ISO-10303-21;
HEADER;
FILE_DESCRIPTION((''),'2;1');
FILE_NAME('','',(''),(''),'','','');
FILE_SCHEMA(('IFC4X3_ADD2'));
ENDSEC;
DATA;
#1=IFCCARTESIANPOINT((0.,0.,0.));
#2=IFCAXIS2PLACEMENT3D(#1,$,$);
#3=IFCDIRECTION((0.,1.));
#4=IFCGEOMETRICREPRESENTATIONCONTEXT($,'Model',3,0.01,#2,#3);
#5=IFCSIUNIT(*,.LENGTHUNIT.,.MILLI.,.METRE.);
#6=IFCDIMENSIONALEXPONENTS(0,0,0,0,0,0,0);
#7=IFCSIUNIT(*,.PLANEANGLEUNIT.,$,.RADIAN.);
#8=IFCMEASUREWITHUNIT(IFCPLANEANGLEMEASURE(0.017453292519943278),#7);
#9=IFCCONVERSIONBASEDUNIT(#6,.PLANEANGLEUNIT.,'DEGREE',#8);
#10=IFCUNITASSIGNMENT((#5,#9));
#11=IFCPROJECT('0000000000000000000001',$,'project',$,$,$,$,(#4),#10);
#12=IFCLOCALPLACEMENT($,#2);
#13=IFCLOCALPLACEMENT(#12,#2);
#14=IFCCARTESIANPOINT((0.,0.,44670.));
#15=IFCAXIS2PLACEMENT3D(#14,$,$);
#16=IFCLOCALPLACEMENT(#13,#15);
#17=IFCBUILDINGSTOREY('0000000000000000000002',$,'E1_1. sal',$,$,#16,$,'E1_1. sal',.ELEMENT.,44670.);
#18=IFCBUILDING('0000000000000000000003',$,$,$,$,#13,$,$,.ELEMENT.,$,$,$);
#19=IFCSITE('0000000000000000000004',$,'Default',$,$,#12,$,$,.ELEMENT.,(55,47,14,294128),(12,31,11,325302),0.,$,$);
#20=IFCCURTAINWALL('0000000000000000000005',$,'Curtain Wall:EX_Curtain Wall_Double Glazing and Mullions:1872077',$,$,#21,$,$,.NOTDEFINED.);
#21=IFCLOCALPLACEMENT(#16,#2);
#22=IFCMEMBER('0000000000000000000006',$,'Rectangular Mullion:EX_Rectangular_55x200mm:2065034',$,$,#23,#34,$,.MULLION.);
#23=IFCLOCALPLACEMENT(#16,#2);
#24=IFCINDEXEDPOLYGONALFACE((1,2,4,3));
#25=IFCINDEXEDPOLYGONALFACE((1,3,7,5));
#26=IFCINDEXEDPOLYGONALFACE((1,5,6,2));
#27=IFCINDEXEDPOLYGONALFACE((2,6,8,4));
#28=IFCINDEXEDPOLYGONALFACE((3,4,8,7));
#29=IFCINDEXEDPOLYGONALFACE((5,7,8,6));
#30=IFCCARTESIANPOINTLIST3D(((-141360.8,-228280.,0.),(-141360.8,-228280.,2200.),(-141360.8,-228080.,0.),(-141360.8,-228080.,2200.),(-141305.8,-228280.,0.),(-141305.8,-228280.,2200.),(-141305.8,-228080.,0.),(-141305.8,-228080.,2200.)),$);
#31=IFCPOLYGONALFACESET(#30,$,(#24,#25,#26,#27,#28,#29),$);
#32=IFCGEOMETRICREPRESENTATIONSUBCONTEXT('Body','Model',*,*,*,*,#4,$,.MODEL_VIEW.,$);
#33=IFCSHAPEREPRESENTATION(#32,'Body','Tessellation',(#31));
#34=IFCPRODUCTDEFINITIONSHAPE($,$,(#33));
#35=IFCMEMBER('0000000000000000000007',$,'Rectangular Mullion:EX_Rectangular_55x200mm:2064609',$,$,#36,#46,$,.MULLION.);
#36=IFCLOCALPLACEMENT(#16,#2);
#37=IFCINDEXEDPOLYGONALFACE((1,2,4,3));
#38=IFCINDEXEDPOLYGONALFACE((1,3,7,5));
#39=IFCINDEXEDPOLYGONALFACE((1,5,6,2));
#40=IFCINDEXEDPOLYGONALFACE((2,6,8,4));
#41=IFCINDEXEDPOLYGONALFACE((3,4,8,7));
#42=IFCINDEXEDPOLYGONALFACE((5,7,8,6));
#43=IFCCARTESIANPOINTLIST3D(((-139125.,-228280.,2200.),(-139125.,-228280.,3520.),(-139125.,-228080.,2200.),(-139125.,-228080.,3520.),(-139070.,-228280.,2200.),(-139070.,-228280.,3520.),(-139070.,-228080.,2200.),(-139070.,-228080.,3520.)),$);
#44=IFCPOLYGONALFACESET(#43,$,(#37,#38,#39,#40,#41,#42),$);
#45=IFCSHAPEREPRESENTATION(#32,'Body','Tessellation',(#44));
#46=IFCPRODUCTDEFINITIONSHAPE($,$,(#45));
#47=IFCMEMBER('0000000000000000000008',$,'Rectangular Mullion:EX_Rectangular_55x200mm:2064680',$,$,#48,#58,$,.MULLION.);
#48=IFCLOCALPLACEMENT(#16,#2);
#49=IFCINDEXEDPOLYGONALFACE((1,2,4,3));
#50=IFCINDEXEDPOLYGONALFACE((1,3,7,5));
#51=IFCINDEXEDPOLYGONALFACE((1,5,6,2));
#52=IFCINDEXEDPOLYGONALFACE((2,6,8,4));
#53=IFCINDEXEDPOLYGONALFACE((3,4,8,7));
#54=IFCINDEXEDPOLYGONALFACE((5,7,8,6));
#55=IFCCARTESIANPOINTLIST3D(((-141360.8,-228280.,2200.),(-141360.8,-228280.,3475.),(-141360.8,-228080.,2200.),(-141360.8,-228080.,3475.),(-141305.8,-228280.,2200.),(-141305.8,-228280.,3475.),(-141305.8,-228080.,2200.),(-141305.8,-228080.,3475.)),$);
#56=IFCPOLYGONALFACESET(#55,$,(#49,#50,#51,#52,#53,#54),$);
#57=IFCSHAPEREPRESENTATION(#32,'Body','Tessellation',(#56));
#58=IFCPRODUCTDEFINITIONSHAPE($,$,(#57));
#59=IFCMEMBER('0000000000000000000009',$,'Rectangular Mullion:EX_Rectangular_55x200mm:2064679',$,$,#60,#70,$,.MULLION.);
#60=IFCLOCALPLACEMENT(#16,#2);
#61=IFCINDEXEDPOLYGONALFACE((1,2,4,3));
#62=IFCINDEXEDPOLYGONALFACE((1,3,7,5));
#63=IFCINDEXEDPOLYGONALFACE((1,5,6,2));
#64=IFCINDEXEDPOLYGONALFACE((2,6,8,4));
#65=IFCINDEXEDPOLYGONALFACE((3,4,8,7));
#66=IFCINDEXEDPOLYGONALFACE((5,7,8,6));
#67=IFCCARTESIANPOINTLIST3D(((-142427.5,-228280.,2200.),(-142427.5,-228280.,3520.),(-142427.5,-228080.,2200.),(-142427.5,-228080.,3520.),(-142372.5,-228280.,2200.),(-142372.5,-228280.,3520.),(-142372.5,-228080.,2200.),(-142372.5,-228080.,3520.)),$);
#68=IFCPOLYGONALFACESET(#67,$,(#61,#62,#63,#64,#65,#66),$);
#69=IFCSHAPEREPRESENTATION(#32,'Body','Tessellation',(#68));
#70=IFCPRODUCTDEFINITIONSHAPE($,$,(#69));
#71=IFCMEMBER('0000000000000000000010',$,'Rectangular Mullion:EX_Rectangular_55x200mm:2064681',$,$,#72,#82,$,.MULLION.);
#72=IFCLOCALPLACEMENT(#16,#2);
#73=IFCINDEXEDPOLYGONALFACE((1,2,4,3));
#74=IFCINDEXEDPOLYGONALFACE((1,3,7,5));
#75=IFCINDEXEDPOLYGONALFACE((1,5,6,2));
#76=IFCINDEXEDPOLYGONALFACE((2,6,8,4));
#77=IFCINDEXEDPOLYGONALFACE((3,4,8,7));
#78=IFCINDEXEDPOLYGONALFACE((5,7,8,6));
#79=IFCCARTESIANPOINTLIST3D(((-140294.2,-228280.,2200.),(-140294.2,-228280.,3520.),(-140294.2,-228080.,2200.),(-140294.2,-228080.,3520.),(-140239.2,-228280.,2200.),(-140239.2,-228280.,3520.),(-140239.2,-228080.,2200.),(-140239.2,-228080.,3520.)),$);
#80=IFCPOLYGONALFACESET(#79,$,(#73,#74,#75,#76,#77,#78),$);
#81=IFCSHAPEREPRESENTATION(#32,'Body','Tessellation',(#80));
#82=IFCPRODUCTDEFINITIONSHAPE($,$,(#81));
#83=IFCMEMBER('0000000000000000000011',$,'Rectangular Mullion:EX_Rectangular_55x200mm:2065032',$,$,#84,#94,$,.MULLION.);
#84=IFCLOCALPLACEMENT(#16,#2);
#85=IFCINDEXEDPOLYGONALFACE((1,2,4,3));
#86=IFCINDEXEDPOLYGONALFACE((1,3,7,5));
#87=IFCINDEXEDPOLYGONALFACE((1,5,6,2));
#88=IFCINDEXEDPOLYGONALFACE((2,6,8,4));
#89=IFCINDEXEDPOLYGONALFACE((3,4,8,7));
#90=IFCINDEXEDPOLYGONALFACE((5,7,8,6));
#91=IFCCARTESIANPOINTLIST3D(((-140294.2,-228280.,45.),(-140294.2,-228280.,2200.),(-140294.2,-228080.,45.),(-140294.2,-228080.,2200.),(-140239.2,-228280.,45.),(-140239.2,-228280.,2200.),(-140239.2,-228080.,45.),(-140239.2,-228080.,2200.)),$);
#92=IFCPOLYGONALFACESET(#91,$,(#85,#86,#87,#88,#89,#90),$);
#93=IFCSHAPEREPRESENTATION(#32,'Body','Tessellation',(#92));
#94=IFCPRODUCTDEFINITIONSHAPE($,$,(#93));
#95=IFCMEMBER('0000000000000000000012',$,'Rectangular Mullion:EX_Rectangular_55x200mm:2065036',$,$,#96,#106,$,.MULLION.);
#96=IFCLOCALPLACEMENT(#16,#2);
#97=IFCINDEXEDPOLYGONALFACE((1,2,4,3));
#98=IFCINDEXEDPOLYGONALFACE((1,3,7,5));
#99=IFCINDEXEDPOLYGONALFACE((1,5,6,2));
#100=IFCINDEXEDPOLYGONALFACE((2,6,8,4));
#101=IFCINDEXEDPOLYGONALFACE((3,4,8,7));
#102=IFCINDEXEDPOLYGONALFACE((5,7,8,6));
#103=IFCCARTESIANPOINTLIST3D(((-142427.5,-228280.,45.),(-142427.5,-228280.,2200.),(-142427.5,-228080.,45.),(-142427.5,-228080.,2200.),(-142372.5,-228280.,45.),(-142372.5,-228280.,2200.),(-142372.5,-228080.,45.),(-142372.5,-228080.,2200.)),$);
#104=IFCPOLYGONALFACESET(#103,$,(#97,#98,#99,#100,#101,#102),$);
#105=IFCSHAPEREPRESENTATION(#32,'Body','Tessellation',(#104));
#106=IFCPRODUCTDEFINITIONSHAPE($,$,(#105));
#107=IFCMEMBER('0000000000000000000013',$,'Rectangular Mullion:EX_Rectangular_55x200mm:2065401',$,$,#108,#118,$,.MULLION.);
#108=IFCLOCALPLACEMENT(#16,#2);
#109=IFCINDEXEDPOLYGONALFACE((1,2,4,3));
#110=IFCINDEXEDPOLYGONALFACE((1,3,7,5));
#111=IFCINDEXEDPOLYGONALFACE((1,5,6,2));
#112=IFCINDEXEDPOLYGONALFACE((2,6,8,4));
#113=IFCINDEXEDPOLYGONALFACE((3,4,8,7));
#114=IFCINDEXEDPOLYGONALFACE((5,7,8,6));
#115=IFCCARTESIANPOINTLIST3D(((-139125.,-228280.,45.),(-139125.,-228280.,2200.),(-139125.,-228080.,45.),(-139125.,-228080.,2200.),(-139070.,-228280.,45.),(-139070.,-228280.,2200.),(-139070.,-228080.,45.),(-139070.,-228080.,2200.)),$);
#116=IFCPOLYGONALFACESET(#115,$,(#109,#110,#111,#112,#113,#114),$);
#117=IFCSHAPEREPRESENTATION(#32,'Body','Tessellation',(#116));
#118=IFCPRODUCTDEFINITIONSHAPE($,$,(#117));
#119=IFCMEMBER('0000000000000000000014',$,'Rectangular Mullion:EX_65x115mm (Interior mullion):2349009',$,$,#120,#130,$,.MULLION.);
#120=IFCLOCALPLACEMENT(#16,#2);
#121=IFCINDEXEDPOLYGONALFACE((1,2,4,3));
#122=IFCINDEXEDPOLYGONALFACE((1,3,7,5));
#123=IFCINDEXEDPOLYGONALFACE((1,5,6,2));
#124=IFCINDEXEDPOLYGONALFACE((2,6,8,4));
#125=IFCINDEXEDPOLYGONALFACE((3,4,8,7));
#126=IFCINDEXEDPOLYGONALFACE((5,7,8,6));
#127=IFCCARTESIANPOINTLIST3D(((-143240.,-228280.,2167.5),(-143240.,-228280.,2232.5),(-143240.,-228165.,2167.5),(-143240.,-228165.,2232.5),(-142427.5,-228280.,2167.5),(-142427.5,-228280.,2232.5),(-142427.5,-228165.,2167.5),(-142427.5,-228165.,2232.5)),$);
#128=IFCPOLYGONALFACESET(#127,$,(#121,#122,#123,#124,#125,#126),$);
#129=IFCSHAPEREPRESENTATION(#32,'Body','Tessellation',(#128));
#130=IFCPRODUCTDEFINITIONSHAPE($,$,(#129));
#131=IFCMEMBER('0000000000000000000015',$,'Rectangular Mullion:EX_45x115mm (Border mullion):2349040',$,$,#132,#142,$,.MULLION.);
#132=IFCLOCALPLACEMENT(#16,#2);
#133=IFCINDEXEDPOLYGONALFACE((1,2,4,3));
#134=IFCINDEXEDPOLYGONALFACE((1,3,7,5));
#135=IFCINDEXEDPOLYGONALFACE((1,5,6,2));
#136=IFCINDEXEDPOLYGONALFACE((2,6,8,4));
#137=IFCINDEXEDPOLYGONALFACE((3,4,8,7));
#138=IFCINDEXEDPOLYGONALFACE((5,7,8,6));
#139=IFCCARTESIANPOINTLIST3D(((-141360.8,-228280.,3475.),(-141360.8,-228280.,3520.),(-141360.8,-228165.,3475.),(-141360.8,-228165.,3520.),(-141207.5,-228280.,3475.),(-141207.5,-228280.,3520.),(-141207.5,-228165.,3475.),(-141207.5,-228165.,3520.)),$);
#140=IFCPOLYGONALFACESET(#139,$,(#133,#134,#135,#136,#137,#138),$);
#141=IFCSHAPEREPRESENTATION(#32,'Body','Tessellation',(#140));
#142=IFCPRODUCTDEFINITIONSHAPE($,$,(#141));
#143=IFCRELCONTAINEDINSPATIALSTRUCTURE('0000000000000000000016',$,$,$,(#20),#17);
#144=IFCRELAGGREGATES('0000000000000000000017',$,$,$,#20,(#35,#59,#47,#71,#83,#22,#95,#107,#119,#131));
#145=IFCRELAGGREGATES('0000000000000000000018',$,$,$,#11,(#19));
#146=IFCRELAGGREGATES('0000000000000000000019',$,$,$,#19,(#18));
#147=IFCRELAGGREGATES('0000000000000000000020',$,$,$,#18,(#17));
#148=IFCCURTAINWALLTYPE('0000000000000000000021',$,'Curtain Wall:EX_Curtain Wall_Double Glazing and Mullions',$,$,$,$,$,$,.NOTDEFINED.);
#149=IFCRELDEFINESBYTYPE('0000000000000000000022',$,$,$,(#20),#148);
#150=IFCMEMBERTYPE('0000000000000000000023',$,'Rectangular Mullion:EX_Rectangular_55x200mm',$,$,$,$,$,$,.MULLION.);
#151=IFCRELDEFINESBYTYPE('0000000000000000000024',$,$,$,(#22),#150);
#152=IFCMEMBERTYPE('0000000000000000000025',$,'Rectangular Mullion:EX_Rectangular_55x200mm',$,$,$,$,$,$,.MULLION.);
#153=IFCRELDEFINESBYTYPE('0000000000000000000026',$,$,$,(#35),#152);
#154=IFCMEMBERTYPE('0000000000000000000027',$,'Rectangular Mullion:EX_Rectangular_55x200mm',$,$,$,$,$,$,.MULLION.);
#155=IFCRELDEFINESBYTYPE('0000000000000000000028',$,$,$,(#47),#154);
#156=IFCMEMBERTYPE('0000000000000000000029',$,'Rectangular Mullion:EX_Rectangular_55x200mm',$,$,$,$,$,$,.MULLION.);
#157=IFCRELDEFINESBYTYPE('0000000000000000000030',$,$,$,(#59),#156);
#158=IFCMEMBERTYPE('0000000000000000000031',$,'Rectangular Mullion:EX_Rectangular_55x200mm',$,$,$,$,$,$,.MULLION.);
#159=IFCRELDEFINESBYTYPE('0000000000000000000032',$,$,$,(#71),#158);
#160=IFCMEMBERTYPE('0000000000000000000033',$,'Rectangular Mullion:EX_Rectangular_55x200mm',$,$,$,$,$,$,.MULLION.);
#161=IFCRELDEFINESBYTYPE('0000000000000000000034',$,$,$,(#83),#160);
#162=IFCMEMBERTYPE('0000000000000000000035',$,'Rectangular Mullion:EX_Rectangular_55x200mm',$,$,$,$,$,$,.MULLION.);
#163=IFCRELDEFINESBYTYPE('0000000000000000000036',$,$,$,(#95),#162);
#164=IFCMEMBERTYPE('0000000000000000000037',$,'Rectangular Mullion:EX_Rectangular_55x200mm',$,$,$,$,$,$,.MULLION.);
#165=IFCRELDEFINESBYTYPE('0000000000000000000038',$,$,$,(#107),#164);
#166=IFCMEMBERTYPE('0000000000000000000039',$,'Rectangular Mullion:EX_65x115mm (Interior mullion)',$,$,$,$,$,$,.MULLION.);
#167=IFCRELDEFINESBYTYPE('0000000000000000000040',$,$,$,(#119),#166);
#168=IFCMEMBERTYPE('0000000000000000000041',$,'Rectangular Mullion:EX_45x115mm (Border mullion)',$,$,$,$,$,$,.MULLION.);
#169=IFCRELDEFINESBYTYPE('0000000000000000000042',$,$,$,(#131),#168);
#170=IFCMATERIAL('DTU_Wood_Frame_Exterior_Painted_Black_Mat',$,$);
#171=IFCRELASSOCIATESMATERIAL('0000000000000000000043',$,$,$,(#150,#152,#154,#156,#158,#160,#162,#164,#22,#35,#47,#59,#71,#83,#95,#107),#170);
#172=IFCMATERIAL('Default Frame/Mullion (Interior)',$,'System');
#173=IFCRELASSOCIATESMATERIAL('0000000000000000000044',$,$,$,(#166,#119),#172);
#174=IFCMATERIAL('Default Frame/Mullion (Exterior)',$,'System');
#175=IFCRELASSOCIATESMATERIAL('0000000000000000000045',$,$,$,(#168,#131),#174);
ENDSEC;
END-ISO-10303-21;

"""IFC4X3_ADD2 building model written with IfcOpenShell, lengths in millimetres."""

from ifc_helpers import new_model, entity, si_unit, converted_unit, direction, frame, origin, origin_2d_with_axis, place, context, subcontext, project, spatial, rectangle, extrude, source, transform, mapped, material, material_profile, profile_set, profile_usage, type_object, type_shapes, element, aggregate, save


model = new_model("IFC4X3_ADD2")

# Units and contexts
model_context = context("Model", 3, precision=0.01, world=origin(), true_north=direction((0.0, 1.0)))
body_context = subcontext(model_context, "Body", "Model", "MODEL_VIEW")
ifc_project = project(units=[si_unit("LENGTHUNIT", "METRE", prefix="MILLI"), converted_unit("PLANEANGLEUNIT", "DEGREE", entity("IfcPlaneAngleMeasure", 0.017453292519943278), si_unit("PLANEANGLEUNIT", "RADIAN"), dimensions=[0, 0, 0, 0, 0, 0, 0])], contexts=[model_context])

# Site, building, storey
site_placement = place(None, origin())
site = spatial("IfcSite", under=ifc_project, at=site_placement, Name="Default", CompositionType="ELEMENT", RefLatitude=(55, 47, 14, 294128), RefLongitude=(12, 31, 11, 325302), RefElevation=0.0)
building_placement = place(site_placement, origin())
building = spatial("IfcBuilding", under=site, at=building_placement, CompositionType="ELEMENT")
storey_placement = place(building_placement, frame((0.0, 0.0, 44670.0)))
storey = spatial("IfcBuildingStorey", under=building, at=storey_placement, Name="E1_1. sal", LongName="E1_1. sal", CompositionType="ELEMENT", Elevation=44670.0)

# Curtain wall, members
curtain_wall_type_1 = type_object("IfcCurtainWallType", Name="Curtain Wall:EX_Curtain Wall_Double Glazing and Mullions", PredefinedType="NOTDEFINED")
curtain_wall_1_placement = place(storey_placement, frame((0.0, 0.0, -44670.0)))
curtain_wall_1 = element("IfcCurtainWall", 1, at=curtain_wall_1_placement, inside=storey, type_object=curtain_wall_type_1, Name="Curtain Wall:EX_Curtain Wall_Double Glazing and Mullions:1872077", PredefinedType="NOTDEFINED")
ifc_material_1 = material(Name="DTU_Wood_Frame_Exterior_Painted_Black_Mat")
ifc_material_profile_1 = material_profile(ifc_material_1, rectangle(XDim=55.0, YDim=200.0, at=origin_2d_with_axis()), Name="EX_Rectangular_55x200mm")
ifc_profile_set_1 = profile_set([ifc_material_profile_1], Name="EX_Rectangular_55x200mm")
ifc_profile_usage_1 = profile_usage(ifc_profile_set_1)
member_type_1 = type_object("IfcMemberType", Name="Rectangular Mullion:EX_Rectangular_55x200mm", PredefinedType="MULLION", material=ifc_profile_set_1)
shared_shape_1 = source(origin(), body_context, "Body", "SweptSolid", [
    extrude(rectangle(XDim=55.0, YDim=200.0, at=origin_2d_with_axis()), frame((0.0, -100.0, -2200.0), z_axis=(0.0, 0.0, 1.0), x_axis=(-1.0, 0.0, 0.0)), (0.0, 0.0, 1.0), 2200.0),
])
type_shapes(member_type_1, [shared_shape_1])
member_1_placement = place(curtain_wall_1_placement, frame((-141333.3, -228280.0, 44670.0), z_axis=(0.0, 0.0, -1.0), x_axis=(1.0, 0.0, 0.0)))
member_1 = element("IfcMember", 2, at=member_1_placement, type_object=member_type_1, material=ifc_profile_usage_1, Name="Rectangular Mullion:EX_Rectangular_55x200mm:2065034", PredefinedType="MULLION", context=body_context, shape_type="MappedRepresentation", body=[
    mapped(shared_shape_1, transform((0.0, 0.0, 0.0), scale=1.0)),
])
member_type_2 = type_object("IfcMemberType", Name="Rectangular Mullion:EX_Rectangular_55x200mm", PredefinedType="MULLION", material=ifc_profile_set_1)
shared_shape_2 = source(origin(), body_context, "Body", "SweptSolid", [
    extrude(rectangle(XDim=55.0, YDim=200.0, at=origin_2d_with_axis()), frame((-27.5, -100.0, -1320.0), z_axis=(0.0, 0.0, 1.0), x_axis=(-1.0, 0.0, 0.0)), (0.0, 0.0, 1.0), 1320.0),
])
type_shapes(member_type_2, [shared_shape_2])
member_2_placement = place(curtain_wall_1_placement, frame((-139070.0, -228280.0, 46870.0), z_axis=(0.0, 0.0, -1.0), x_axis=(1.0, 0.0, 0.0)))
member_2 = element("IfcMember", 3, at=member_2_placement, type_object=member_type_2, material=ifc_profile_usage_1, Name="Rectangular Mullion:EX_Rectangular_55x200mm:2064609", PredefinedType="MULLION", context=body_context, shape_type="MappedRepresentation", body=[
    mapped(shared_shape_2, transform((0.0, 0.0, 0.0), scale=1.0)),
])
member_type_3 = type_object("IfcMemberType", Name="Rectangular Mullion:EX_Rectangular_55x200mm", PredefinedType="MULLION", material=ifc_profile_set_1)
shared_shape_3 = source(origin(), body_context, "Body", "SweptSolid", [
    extrude(rectangle(XDim=55.0, YDim=200.0, at=origin_2d_with_axis()), frame((0.0, -100.0, -1275.0), z_axis=(0.0, 0.0, 1.0), x_axis=(-1.0, 0.0, 0.0)), (0.0, 0.0, 1.0), 1275.0),
])
type_shapes(member_type_3, [shared_shape_3])
member_3_placement = place(curtain_wall_1_placement, frame((-141333.3, -228280.0, 46870.0), z_axis=(0.0, 0.0, -1.0), x_axis=(1.0, 0.0, 0.0)))
member_3 = element("IfcMember", 4, at=member_3_placement, type_object=member_type_3, material=ifc_profile_usage_1, Name="Rectangular Mullion:EX_Rectangular_55x200mm:2064680", PredefinedType="MULLION", context=body_context, shape_type="MappedRepresentation", body=[
    mapped(shared_shape_3, transform((0.0, 0.0, 0.0), scale=1.0)),
])
member_type_4 = type_object("IfcMemberType", Name="Rectangular Mullion:EX_Rectangular_55x200mm", PredefinedType="MULLION", material=ifc_profile_set_1)
shared_shape_4 = source(origin(), body_context, "Body", "SweptSolid", [
    extrude(rectangle(XDim=55.0, YDim=200.0, at=origin_2d_with_axis()), frame((0.0, -100.0, -1320.0), z_axis=(0.0, 0.0, 1.0), x_axis=(-1.0, 0.0, 0.0)), (0.0, 0.0, 1.0), 1320.0),
])
type_shapes(member_type_4, [shared_shape_4])
member_4_placement = place(curtain_wall_1_placement, frame((-142400.0, -228280.0, 46870.0), z_axis=(0.0, 0.0, -1.0), x_axis=(1.0, 0.0, 0.0)))
member_4 = element("IfcMember", 5, at=member_4_placement, type_object=member_type_4, material=ifc_profile_usage_1, Name="Rectangular Mullion:EX_Rectangular_55x200mm:2064679", PredefinedType="MULLION", context=body_context, shape_type="MappedRepresentation", body=[
    mapped(shared_shape_4, transform((0.0, 0.0, 0.0), scale=1.0)),
])
member_type_5 = type_object("IfcMemberType", Name="Rectangular Mullion:EX_Rectangular_55x200mm", PredefinedType="MULLION", material=ifc_profile_set_1)
shared_shape_5 = source(origin(), body_context, "Body", "SweptSolid", [
    extrude(rectangle(XDim=55.0, YDim=200.0, at=origin_2d_with_axis()), frame((0.0, -100.0, -1320.0), z_axis=(0.0, 0.0, 1.0), x_axis=(-1.0, 0.0, 0.0)), (0.0, 0.0, 1.0), 1320.0),
])
type_shapes(member_type_5, [shared_shape_5])
member_5_placement = place(curtain_wall_1_placement, frame((-140266.7, -228280.0, 46870.0), z_axis=(0.0, 0.0, -1.0), x_axis=(1.0, 0.0, 0.0)))
member_5 = element("IfcMember", 6, at=member_5_placement, type_object=member_type_5, material=ifc_profile_usage_1, Name="Rectangular Mullion:EX_Rectangular_55x200mm:2064681", PredefinedType="MULLION", context=body_context, shape_type="MappedRepresentation", body=[
    mapped(shared_shape_5, transform((0.0, 0.0, 0.0), scale=1.0)),
])
member_type_6 = type_object("IfcMemberType", Name="Rectangular Mullion:EX_Rectangular_55x200mm", PredefinedType="MULLION", material=ifc_profile_set_1)
shared_shape_6 = source(origin(), body_context, "Body", "SweptSolid", [
    extrude(rectangle(XDim=55.0, YDim=200.0, at=origin_2d_with_axis()), frame((0.0, -100.0, -2155.0), z_axis=(0.0, 0.0, 1.0), x_axis=(-1.0, 0.0, 0.0)), (0.0, 0.0, 1.0), 2155.0),
])
type_shapes(member_type_6, [shared_shape_6])
member_6_placement = place(curtain_wall_1_placement, frame((-140266.7, -228280.0, 44715.0), z_axis=(0.0, 0.0, -1.0), x_axis=(1.0, 0.0, 0.0)))
member_6 = element("IfcMember", 7, at=member_6_placement, type_object=member_type_6, material=ifc_profile_usage_1, Name="Rectangular Mullion:EX_Rectangular_55x200mm:2065032", PredefinedType="MULLION", context=body_context, shape_type="MappedRepresentation", body=[
    mapped(shared_shape_6, transform((0.0, 0.0, 0.0), scale=1.0)),
])
member_type_7 = type_object("IfcMemberType", Name="Rectangular Mullion:EX_Rectangular_55x200mm", PredefinedType="MULLION", material=ifc_profile_set_1)
shared_shape_7 = source(origin(), body_context, "Body", "SweptSolid", [
    extrude(rectangle(XDim=55.0, YDim=200.0, at=origin_2d_with_axis()), frame((0.0, -100.0, -2155.0), z_axis=(0.0, 0.0, 1.0), x_axis=(-1.0, 0.0, 0.0)), (0.0, 0.0, 1.0), 2155.0),
])
type_shapes(member_type_7, [shared_shape_7])
member_7_placement = place(curtain_wall_1_placement, frame((-142400.0, -228280.0, 44715.0), z_axis=(0.0, 0.0, -1.0), x_axis=(1.0, 0.0, 0.0)))
member_7 = element("IfcMember", 8, at=member_7_placement, type_object=member_type_7, material=ifc_profile_usage_1, Name="Rectangular Mullion:EX_Rectangular_55x200mm:2065036", PredefinedType="MULLION", context=body_context, shape_type="MappedRepresentation", body=[
    mapped(shared_shape_7, transform((0.0, 0.0, 0.0), scale=1.0)),
])
member_type_8 = type_object("IfcMemberType", Name="Rectangular Mullion:EX_Rectangular_55x200mm", PredefinedType="MULLION", material=ifc_profile_set_1)
shared_shape_8 = source(origin(), body_context, "Body", "SweptSolid", [
    extrude(rectangle(XDim=55.0, YDim=200.0, at=origin_2d_with_axis()), frame((-27.5, -100.0, -2155.0), z_axis=(0.0, 0.0, 1.0), x_axis=(-1.0, 0.0, 0.0)), (0.0, 0.0, 1.0), 2155.0),
])
type_shapes(member_type_8, [shared_shape_8])
member_8_placement = place(curtain_wall_1_placement, frame((-139070.0, -228280.0, 44715.0), z_axis=(0.0, 0.0, -1.0), x_axis=(1.0, 0.0, 0.0)))
member_8 = element("IfcMember", 9, at=member_8_placement, type_object=member_type_8, material=ifc_profile_usage_1, Name="Rectangular Mullion:EX_Rectangular_55x200mm:2065401", PredefinedType="MULLION", context=body_context, shape_type="MappedRepresentation", body=[
    mapped(shared_shape_8, transform((0.0, 0.0, 0.0), scale=1.0)),
])
ifc_material_2 = material(Name="Default Frame/Mullion (Interior)", Category="System")
ifc_material_profile_2 = material_profile(ifc_material_2, rectangle(XDim=65.0, YDim=115.0, at=origin_2d_with_axis()), Name="EX_65x115mm (Interior mullion)")
ifc_profile_set_2 = profile_set([ifc_material_profile_2], Name="EX_65x115mm (Interior mullion)")
ifc_profile_usage_2 = profile_usage(ifc_profile_set_2)
member_type_9 = type_object("IfcMemberType", Name="Rectangular Mullion:EX_65x115mm (Interior mullion)", PredefinedType="MULLION", material=ifc_profile_set_2)
shared_shape_9 = source(origin(), body_context, "Body", "SweptSolid", [
    extrude(rectangle(XDim=65.0, YDim=115.0, at=origin_2d_with_axis()), frame((0.0, -57.5, -812.5), z_axis=(0.0, 0.0, 1.0), x_axis=(-1.0, 0.0, 0.0)), (0.0, 0.0, 1.0), 812.5),
])
type_shapes(member_type_9, [shared_shape_9])
member_9_placement = place(curtain_wall_1_placement, frame((-142427.5, -228280.0, 46870.0), z_axis=(1.0, 0.0, 0.0), x_axis=(0.0, 0.0, 1.0)))
member_9 = element("IfcMember", 10, at=member_9_placement, type_object=member_type_9, material=ifc_profile_usage_2, Name="Rectangular Mullion:EX_65x115mm (Interior mullion):2349009", PredefinedType="MULLION", context=body_context, shape_type="MappedRepresentation", body=[
    mapped(shared_shape_9, transform((0.0, 0.0, 0.0), scale=1.0)),
])
ifc_material_3 = material(Name="Default Frame/Mullion (Exterior)", Category="System")
ifc_material_profile_3 = material_profile(ifc_material_3, rectangle(XDim=45.0, YDim=115.0, at=origin_2d_with_axis()), Name="EX_45x115mm (Border mullion)")
ifc_profile_set_3 = profile_set([ifc_material_profile_3], Name="EX_45x115mm (Border mullion)")
ifc_profile_usage_3 = profile_usage(ifc_profile_set_3)
member_type_10 = type_object("IfcMemberType", Name="Rectangular Mullion:EX_45x115mm (Border mullion)", PredefinedType="MULLION", material=ifc_profile_set_3)
shared_shape_10 = source(origin(), body_context, "Body", "SweptSolid", [
    extrude(rectangle(XDim=45.0, YDim=115.0, at=origin_2d_with_axis()), frame((-22.5, -57.5, -153.3), z_axis=(0.0, 0.0, 1.0), x_axis=(-1.0, 0.0, 0.0)), (0.0, 0.0, 1.0), 153.3),
])
type_shapes(member_type_10, [shared_shape_10])
member_10_placement = place(curtain_wall_1_placement, frame((-141207.5, -228280.0, 48190.0), z_axis=(1.0, 0.0, 0.0), x_axis=(0.0, 0.0, 1.0)))
member_10 = element("IfcMember", 11, at=member_10_placement, type_object=member_type_10, material=ifc_profile_usage_3, Name="Rectangular Mullion:EX_45x115mm (Border mullion):2349040", PredefinedType="MULLION", context=body_context, shape_type="MappedRepresentation", body=[
    mapped(shared_shape_10, transform((0.0, 0.0, 0.0), scale=1.0)),
])

aggregate(curtain_wall_1, [member_2, member_4, member_3, member_5, member_6, member_1, member_7, member_8, member_9, member_10])

save(model, "model.ifc")
